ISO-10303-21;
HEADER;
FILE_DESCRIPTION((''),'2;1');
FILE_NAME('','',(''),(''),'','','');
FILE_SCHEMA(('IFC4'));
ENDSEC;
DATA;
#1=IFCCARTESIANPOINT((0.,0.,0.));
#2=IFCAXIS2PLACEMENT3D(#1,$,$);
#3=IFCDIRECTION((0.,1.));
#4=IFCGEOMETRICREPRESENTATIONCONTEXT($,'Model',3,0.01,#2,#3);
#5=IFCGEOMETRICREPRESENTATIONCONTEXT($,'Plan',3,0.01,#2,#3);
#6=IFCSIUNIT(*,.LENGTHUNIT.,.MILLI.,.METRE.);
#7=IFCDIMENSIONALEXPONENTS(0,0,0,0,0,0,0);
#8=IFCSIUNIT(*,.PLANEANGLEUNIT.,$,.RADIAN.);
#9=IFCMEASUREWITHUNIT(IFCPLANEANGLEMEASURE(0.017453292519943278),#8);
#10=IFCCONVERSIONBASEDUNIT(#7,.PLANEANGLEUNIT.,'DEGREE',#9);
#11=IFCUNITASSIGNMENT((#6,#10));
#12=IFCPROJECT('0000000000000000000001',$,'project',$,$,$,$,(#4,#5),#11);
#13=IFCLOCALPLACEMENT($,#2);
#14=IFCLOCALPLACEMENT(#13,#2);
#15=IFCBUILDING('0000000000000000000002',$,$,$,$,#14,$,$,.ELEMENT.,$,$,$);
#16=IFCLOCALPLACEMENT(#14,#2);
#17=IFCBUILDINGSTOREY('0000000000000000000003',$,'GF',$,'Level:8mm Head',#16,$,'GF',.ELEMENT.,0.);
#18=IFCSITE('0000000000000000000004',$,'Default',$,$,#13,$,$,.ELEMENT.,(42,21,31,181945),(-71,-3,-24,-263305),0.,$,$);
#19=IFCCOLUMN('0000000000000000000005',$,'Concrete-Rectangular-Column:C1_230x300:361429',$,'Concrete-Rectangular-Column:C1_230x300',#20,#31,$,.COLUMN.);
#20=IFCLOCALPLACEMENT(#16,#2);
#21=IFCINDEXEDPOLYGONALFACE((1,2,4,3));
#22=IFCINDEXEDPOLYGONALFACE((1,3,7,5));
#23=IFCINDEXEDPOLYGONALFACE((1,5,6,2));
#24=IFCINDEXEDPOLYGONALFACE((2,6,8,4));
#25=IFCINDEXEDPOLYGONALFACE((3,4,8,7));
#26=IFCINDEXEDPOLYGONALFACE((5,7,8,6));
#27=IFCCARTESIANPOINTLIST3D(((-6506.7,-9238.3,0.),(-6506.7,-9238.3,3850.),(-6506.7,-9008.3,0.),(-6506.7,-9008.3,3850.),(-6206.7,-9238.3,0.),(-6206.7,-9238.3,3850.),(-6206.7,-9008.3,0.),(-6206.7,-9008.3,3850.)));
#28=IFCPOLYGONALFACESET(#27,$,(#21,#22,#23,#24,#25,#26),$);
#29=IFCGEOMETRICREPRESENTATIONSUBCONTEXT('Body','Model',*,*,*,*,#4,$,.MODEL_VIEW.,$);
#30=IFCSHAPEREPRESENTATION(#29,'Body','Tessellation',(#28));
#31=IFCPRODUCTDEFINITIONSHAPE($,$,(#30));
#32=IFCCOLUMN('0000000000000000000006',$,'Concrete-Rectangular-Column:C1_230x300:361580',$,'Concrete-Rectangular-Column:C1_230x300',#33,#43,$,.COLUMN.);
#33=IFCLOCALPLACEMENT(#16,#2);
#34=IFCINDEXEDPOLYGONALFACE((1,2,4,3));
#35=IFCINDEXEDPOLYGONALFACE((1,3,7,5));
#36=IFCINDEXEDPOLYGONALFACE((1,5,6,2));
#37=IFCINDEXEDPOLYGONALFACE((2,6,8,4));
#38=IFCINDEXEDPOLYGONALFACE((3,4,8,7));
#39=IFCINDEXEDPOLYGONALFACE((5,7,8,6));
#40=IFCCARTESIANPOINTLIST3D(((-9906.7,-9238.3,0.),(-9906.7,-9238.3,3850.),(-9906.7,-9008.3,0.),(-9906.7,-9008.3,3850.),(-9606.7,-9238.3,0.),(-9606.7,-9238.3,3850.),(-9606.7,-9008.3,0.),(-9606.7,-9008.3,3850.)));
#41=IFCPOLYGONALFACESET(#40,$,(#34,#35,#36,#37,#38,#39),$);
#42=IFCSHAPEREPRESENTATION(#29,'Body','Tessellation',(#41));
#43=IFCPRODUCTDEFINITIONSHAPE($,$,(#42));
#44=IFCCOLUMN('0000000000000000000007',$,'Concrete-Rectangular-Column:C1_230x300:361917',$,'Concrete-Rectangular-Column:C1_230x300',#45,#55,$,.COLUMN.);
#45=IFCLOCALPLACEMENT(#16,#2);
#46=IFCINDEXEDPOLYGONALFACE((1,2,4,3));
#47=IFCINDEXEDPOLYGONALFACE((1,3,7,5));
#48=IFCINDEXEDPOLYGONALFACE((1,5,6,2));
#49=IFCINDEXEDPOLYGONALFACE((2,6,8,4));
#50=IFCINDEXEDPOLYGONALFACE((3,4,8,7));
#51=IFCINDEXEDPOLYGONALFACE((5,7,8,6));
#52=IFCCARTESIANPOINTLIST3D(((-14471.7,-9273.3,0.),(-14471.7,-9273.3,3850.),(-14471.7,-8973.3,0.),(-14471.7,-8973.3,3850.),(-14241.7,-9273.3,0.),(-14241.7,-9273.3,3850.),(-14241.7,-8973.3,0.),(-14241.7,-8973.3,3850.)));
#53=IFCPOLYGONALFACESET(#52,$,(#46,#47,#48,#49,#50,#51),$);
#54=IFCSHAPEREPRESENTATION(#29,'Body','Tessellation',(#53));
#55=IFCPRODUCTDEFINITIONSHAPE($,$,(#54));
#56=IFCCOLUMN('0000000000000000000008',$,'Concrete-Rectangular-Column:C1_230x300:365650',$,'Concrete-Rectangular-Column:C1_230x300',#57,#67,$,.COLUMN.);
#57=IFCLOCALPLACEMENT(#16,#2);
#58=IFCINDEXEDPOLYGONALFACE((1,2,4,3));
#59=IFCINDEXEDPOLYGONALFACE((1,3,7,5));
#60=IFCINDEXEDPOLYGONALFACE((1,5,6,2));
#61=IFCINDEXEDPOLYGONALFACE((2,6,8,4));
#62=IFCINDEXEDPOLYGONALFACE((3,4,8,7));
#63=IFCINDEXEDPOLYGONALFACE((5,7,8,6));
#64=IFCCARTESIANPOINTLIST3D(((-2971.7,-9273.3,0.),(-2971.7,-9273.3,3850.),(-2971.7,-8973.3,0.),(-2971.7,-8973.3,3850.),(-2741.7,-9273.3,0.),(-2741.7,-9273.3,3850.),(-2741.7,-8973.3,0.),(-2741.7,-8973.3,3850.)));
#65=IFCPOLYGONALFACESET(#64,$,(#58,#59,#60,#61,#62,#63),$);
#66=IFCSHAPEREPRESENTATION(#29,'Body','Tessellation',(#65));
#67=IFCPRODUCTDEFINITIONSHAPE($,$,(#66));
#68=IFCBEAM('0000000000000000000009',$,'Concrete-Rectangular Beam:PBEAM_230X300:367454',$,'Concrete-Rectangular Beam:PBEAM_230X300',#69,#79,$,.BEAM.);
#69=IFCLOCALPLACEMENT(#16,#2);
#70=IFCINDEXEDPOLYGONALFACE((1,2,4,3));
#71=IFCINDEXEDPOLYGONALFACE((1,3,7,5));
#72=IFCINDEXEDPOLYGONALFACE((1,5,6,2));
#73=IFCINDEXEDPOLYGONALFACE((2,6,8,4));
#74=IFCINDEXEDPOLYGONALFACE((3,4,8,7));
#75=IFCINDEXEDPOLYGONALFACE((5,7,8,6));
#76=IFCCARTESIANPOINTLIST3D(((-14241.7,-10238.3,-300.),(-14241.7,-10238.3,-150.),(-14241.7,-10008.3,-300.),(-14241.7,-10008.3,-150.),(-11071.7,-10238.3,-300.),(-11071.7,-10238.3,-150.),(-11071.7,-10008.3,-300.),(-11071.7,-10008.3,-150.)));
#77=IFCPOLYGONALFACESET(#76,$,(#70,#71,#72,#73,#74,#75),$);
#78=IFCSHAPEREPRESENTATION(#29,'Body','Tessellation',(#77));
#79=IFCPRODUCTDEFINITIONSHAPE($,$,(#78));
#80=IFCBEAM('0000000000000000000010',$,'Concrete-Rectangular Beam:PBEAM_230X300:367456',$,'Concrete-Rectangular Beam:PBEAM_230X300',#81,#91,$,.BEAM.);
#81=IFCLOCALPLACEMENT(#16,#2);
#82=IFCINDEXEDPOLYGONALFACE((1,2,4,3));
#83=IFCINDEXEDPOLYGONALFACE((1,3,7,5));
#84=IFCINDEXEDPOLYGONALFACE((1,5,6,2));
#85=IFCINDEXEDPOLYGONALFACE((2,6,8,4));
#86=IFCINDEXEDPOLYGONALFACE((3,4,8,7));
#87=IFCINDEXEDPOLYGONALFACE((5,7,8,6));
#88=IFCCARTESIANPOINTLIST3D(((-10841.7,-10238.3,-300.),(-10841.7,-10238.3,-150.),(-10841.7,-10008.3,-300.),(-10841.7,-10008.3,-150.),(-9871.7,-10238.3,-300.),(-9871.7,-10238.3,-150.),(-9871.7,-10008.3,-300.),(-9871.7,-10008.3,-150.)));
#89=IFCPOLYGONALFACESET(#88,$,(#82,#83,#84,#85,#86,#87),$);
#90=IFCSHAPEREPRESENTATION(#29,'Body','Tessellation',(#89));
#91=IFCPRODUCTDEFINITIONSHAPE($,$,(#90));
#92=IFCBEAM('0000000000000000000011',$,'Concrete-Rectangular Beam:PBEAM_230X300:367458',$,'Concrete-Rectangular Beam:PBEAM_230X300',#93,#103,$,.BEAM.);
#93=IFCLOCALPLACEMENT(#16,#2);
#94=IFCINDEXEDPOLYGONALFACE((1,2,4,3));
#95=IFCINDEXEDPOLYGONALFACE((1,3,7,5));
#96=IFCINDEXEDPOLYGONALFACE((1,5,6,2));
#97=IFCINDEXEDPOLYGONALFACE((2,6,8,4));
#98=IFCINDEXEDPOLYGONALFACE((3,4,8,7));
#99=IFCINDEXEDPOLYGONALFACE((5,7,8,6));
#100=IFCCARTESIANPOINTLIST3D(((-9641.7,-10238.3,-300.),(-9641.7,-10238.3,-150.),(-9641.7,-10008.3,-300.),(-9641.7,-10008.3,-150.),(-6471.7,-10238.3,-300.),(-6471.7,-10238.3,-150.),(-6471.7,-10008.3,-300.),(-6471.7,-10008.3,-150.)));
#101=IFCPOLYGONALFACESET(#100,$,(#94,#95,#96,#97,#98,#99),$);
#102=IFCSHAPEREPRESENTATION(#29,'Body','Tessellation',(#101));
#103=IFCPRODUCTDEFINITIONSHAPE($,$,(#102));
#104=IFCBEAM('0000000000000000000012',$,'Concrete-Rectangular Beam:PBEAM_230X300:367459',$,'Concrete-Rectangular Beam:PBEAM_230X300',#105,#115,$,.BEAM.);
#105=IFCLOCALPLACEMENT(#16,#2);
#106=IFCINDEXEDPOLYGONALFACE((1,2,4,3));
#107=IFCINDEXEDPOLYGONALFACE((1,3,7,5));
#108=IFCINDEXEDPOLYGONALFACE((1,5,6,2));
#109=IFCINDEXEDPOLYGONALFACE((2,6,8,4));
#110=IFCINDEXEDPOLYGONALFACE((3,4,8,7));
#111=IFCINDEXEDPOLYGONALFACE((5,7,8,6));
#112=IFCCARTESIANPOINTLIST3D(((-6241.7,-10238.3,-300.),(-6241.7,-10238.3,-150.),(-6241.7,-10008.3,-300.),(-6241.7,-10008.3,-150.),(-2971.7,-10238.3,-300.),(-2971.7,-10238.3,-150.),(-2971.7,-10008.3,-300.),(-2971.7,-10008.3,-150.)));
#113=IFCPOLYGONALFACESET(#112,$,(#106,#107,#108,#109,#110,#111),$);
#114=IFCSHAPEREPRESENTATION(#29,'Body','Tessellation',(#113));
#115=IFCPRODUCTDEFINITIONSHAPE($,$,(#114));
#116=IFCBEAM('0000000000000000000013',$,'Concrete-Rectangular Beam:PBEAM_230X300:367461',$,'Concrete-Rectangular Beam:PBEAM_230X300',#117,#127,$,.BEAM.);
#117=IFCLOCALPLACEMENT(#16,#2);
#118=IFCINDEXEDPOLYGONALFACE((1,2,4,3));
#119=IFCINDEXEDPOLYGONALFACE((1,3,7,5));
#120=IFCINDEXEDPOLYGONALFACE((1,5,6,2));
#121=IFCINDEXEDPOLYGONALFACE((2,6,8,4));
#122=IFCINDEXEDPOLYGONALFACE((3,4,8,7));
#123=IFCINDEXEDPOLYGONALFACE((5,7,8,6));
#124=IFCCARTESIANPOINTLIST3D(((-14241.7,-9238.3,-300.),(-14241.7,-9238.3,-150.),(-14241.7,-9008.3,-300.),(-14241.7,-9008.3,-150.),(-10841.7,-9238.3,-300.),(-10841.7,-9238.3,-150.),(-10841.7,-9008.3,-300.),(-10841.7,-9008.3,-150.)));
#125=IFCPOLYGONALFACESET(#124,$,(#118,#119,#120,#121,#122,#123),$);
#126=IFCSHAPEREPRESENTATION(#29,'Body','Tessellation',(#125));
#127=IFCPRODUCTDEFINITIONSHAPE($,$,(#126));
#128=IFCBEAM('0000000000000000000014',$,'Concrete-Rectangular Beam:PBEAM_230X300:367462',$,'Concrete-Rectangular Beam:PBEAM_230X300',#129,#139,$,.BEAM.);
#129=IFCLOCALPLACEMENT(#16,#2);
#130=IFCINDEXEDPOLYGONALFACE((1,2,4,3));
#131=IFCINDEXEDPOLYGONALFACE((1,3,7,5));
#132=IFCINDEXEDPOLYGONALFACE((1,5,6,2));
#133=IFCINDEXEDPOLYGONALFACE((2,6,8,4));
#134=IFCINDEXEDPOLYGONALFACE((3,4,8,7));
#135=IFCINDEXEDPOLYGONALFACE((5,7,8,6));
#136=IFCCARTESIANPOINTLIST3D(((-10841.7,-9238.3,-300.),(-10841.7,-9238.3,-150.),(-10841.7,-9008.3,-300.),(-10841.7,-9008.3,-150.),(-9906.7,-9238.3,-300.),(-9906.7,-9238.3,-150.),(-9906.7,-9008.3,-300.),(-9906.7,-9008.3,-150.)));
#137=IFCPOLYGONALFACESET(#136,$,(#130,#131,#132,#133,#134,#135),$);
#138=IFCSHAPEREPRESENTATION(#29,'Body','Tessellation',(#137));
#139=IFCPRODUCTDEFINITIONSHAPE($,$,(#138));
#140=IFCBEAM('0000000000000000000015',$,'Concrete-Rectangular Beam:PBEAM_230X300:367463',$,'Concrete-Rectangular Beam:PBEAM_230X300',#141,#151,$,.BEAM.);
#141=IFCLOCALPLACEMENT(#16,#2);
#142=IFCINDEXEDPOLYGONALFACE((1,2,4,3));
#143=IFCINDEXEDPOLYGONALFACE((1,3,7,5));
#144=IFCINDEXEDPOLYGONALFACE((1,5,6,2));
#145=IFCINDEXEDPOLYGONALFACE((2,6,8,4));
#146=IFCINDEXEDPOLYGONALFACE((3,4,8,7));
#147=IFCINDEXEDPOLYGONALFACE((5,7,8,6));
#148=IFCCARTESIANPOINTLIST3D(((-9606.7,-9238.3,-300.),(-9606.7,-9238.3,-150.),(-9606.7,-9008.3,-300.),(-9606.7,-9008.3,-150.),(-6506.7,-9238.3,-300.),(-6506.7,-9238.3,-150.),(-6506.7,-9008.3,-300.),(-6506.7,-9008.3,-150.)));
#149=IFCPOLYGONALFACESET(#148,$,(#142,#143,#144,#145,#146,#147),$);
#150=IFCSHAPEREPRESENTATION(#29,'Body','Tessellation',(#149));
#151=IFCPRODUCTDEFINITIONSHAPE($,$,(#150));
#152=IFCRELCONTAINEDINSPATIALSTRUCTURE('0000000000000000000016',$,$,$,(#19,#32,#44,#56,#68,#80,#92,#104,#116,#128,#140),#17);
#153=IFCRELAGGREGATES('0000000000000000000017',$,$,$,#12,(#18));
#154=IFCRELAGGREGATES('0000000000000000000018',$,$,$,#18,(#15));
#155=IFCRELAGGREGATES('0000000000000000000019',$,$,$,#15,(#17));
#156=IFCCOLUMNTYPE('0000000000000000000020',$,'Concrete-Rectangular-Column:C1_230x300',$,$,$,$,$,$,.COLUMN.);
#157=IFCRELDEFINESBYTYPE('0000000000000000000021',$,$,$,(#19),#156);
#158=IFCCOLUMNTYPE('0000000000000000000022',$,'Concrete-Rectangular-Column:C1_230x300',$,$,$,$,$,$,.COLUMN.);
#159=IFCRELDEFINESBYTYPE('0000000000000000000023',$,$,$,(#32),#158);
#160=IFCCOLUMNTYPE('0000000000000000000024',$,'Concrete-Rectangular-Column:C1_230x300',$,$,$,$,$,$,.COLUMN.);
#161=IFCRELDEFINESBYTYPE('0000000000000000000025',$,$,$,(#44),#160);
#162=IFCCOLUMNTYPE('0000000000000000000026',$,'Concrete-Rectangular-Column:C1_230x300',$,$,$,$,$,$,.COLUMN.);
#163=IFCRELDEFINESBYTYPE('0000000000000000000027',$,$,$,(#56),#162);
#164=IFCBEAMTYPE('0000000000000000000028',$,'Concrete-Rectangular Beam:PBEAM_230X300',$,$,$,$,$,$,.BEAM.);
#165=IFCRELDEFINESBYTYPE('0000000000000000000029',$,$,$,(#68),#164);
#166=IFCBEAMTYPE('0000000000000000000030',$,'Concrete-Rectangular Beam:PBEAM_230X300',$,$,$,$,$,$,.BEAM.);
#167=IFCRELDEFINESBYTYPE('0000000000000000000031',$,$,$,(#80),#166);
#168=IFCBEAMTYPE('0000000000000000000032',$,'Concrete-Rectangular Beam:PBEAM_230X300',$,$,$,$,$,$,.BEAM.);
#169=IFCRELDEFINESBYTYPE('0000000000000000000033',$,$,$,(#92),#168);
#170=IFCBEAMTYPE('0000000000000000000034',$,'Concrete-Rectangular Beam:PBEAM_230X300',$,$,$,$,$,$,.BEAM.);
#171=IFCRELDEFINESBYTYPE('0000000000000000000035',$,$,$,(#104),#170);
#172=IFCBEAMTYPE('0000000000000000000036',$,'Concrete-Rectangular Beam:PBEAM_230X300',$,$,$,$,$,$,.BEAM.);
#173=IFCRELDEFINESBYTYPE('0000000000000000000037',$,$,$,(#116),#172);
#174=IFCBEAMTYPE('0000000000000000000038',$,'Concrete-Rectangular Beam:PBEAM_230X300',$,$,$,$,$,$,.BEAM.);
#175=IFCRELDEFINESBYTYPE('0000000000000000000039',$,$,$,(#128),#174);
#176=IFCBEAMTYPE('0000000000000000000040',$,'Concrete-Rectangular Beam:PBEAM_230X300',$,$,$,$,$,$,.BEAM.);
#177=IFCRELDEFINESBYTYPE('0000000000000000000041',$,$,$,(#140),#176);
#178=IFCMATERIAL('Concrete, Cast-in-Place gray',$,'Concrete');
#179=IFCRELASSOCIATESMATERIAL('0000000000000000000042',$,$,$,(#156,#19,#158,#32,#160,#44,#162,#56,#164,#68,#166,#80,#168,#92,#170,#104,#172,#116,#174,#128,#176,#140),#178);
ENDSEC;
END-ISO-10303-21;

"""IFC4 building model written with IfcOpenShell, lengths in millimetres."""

from ifc_helpers import new_model, entity, si_unit, converted_unit, direction, frame, origin, place, context, subcontext, project, spatial, indexed_curve, outline, extrude, source, transform, mapped, material, type_object, type_shapes, element, save


model = new_model("IFC4")

# Units and contexts
model_context = context("Model", 3, precision=0.01, world=origin(), true_north=direction((0.0, 1.0)))
plan_context = context("Plan", 3, precision=0.01, world=origin(), true_north=direction((0.0, 1.0)))
body_context = subcontext(model_context, "Body", "Model", "MODEL_VIEW")
ifc_project = project(units=[si_unit("LENGTHUNIT", "METRE", prefix="MILLI"), converted_unit("PLANEANGLEUNIT", "DEGREE", entity("IfcPlaneAngleMeasure", 0.017453292519943278), si_unit("PLANEANGLEUNIT", "RADIAN"), dimensions=[0, 0, 0, 0, 0, 0, 0])], contexts=[model_context, plan_context])

# Site, building, storey
site_placement = place(None, origin())
site = spatial("IfcSite", under=ifc_project, at=site_placement, Name="Default", CompositionType="ELEMENT", RefLatitude=(42, 21, 31, 181945), RefLongitude=(-71, -3, -24, -263305), RefElevation=0.0)
building_placement = place(site_placement, origin())
building = spatial("IfcBuilding", under=site, at=building_placement, CompositionType="ELEMENT")
storey_placement = place(building_placement, origin())
storey = spatial("IfcBuildingStorey", under=building, at=storey_placement, Name="GF", ObjectType="Level:8mm Head", LongName="GF", CompositionType="ELEMENT", Elevation=0.0)

# Columns
ifc_material = material(Name="Concrete, Cast-in-Place gray", Category="Concrete")
column_type_1 = type_object("IfcColumnType", Name="Concrete-Rectangular-Column:C1_230x300", PredefinedType="COLUMN", material=ifc_material)
shared_shape_1 = source(origin(), body_context, "Body", "SweptSolid", [
    extrude(outline(indexed_curve([(-115.0, -150.0), (115.0, -150.0), (115.0, 150.0), (-115.0, 150.0), (-115.0, -150.0)], self_intersect=False)), frame((-6356.7, -9123.3, 0.0), z_axis=(0.0, 0.0, 1.0), x_axis=(0.0, -1.0, 0.0)), (0.0, 0.0, 1.0), 3850.0),
])
type_shapes(column_type_1, [shared_shape_1])
column_1_placement = place(storey_placement, origin())
element("IfcColumn", 1, at=column_1_placement, inside=storey, type_object=column_type_1, material=ifc_material, Name="Concrete-Rectangular-Column:C1_230x300:361429", ObjectType="Concrete-Rectangular-Column:C1_230x300", PredefinedType="COLUMN", context=body_context, shape_type="MappedRepresentation", body=[
    mapped(shared_shape_1, transform((0.0, 0.0, 0.0), scale=1.0)),
])
column_type_2 = type_object("IfcColumnType", Name="Concrete-Rectangular-Column:C1_230x300", PredefinedType="COLUMN", material=ifc_material)
shared_shape_2 = source(origin(), body_context, "Body", "SweptSolid", [
    extrude(outline(indexed_curve([(-115.0, -150.0), (115.0, -150.0), (115.0, 150.0), (-115.0, 150.0), (-115.0, -150.0)], self_intersect=False)), frame((-9756.7, -9123.3, 0.0), z_axis=(0.0, 0.0, 1.0), x_axis=(0.0, -1.0, 0.0)), (0.0, 0.0, 1.0), 3850.0),
])
type_shapes(column_type_2, [shared_shape_2])
column_2_placement = place(storey_placement, origin())
element("IfcColumn", 2, at=column_2_placement, inside=storey, type_object=column_type_2, material=ifc_material, Name="Concrete-Rectangular-Column:C1_230x300:361580", ObjectType="Concrete-Rectangular-Column:C1_230x300", PredefinedType="COLUMN", context=body_context, shape_type="MappedRepresentation", body=[
    mapped(shared_shape_2, transform((0.0, 0.0, 0.0), scale=1.0)),
])
column_type_3 = type_object("IfcColumnType", Name="Concrete-Rectangular-Column:C1_230x300", PredefinedType="COLUMN", material=ifc_material)
shared_shape_3 = source(origin(), body_context, "Body", "SweptSolid", [
    extrude(outline(indexed_curve([(-1925.0, -150.0), (1925.0, -150.0), (1925.0, 150.0), (-1925.0, 150.0), (-1925.0, -150.0)], self_intersect=False)), frame((-14471.7, -9123.3, 1925.0), z_axis=(1.0, 0.0, 0.0), x_axis=(0.0, 0.0, 1.0)), (0.0, 0.0, 1.0), 230.0),
])
type_shapes(column_type_3, [shared_shape_3])
column_3_placement = place(storey_placement, origin())
element("IfcColumn", 3, at=column_3_placement, inside=storey, type_object=column_type_3, material=ifc_material, Name="Concrete-Rectangular-Column:C1_230x300:361917", ObjectType="Concrete-Rectangular-Column:C1_230x300", PredefinedType="COLUMN", context=body_context, shape_type="MappedRepresentation", body=[
    mapped(shared_shape_3, transform((0.0, 0.0, 0.0), scale=1.0)),
])
column_type_4 = type_object("IfcColumnType", Name="Concrete-Rectangular-Column:C1_230x300", PredefinedType="COLUMN", material=ifc_material)
shared_shape_4 = source(origin(), body_context, "Body", "SweptSolid", [
    extrude(outline(indexed_curve([(-1925.0, -150.0), (1925.0, -150.0), (1925.0, 150.0), (-1925.0, 150.0), (-1925.0, -150.0)], self_intersect=False)), frame((-2971.7, -9123.3, 1925.0), z_axis=(1.0, 0.0, 0.0), x_axis=(0.0, 0.0, 1.0)), (0.0, 0.0, 1.0), 230.0),
])
type_shapes(column_type_4, [shared_shape_4])
column_4_placement = place(storey_placement, origin())
element("IfcColumn", 4, at=column_4_placement, inside=storey, type_object=column_type_4, material=ifc_material, Name="Concrete-Rectangular-Column:C1_230x300:365650", ObjectType="Concrete-Rectangular-Column:C1_230x300", PredefinedType="COLUMN", context=body_context, shape_type="MappedRepresentation", body=[
    mapped(shared_shape_4, transform((0.0, 0.0, 0.0), scale=1.0)),
])

# Beams
beam_type_1 = type_object("IfcBeamType", Name="Concrete-Rectangular Beam:PBEAM_230X300", PredefinedType="BEAM", material=ifc_material)
shared_shape_5 = source(origin(), body_context, "Body", "SweptSolid", [
    extrude(outline(indexed_curve([(-75.0, -115.0), (75.0, -115.0), (75.0, 115.0), (-75.0, 115.0), (-75.0, -115.0)], self_intersect=False)), frame((-14241.7, -10123.3, -225.0), z_axis=(1.0, 0.0, 0.0), x_axis=(0.0, 0.0, -1.0)), (0.0, 0.0, 1.0), 3170.0),
])
type_shapes(beam_type_1, [shared_shape_5])
beam_1_placement = place(storey_placement, origin())
element("IfcBeam", 5, at=beam_1_placement, inside=storey, type_object=beam_type_1, material=ifc_material, Name="Concrete-Rectangular Beam:PBEAM_230X300:367454", ObjectType="Concrete-Rectangular Beam:PBEAM_230X300", PredefinedType="BEAM", context=body_context, shape_type="MappedRepresentation", body=[
    mapped(shared_shape_5, transform((0.0, 0.0, 0.0), scale=1.0)),
])
beam_type_2 = type_object("IfcBeamType", Name="Concrete-Rectangular Beam:PBEAM_230X300", PredefinedType="BEAM", material=ifc_material)
shared_shape_6 = source(origin(), body_context, "Body", "SweptSolid", [
    extrude(outline(indexed_curve([(-75.0, -115.0), (75.0, -115.0), (75.0, 115.0), (-75.0, 115.0), (-75.0, -115.0)], self_intersect=False)), frame((-10841.7, -10123.3, -225.0), z_axis=(1.0, 0.0, 0.0), x_axis=(0.0, 0.0, -1.0)), (0.0, 0.0, 1.0), 970.0),
])
type_shapes(beam_type_2, [shared_shape_6])
beam_2_placement = place(storey_placement, origin())
element("IfcBeam", 6, at=beam_2_placement, inside=storey, type_object=beam_type_2, material=ifc_material, Name="Concrete-Rectangular Beam:PBEAM_230X300:367456", ObjectType="Concrete-Rectangular Beam:PBEAM_230X300", PredefinedType="BEAM", context=body_context, shape_type="MappedRepresentation", body=[
    mapped(shared_shape_6, transform((0.0, 0.0, 0.0), scale=1.0)),
])
beam_type_3 = type_object("IfcBeamType", Name="Concrete-Rectangular Beam:PBEAM_230X300", PredefinedType="BEAM", material=ifc_material)
shared_shape_7 = source(origin(), body_context, "Body", "SweptSolid", [
    extrude(outline(indexed_curve([(-75.0, -115.0), (75.0, -115.0), (75.0, 115.0), (-75.0, 115.0), (-75.0, -115.0)], self_intersect=False)), frame((-9641.7, -10123.3, -225.0), z_axis=(1.0, 0.0, 0.0), x_axis=(0.0, 0.0, -1.0)), (0.0, 0.0, 1.0), 3170.0),
])
type_shapes(beam_type_3, [shared_shape_7])
beam_3_placement = place(storey_placement, origin())
element("IfcBeam", 7, at=beam_3_placement, inside=storey, type_object=beam_type_3, material=ifc_material, Name="Concrete-Rectangular Beam:PBEAM_230X300:367458", ObjectType="Concrete-Rectangular Beam:PBEAM_230X300", PredefinedType="BEAM", context=body_context, shape_type="MappedRepresentation", body=[
    mapped(shared_shape_7, transform((0.0, 0.0, 0.0), scale=1.0)),
])
beam_type_4 = type_object("IfcBeamType", Name="Concrete-Rectangular Beam:PBEAM_230X300", PredefinedType="BEAM", material=ifc_material)
shared_shape_8 = source(origin(), body_context, "Body", "SweptSolid", [
    extrude(outline(indexed_curve([(-75.0, -115.0), (75.0, -115.0), (75.0, 115.0), (-75.0, 115.0), (-75.0, -115.0)], self_intersect=False)), frame((-6241.7, -10123.3, -225.0), z_axis=(1.0, 0.0, 0.0), x_axis=(0.0, 0.0, -1.0)), (0.0, 0.0, 1.0), 3270.0),
])
type_shapes(beam_type_4, [shared_shape_8])
beam_4_placement = place(storey_placement, origin())
element("IfcBeam", 8, at=beam_4_placement, inside=storey, type_object=beam_type_4, material=ifc_material, Name="Concrete-Rectangular Beam:PBEAM_230X300:367459", ObjectType="Concrete-Rectangular Beam:PBEAM_230X300", PredefinedType="BEAM", context=body_context, shape_type="MappedRepresentation", body=[
    mapped(shared_shape_8, transform((0.0, 0.0, 0.0), scale=1.0)),
])
beam_type_5 = type_object("IfcBeamType", Name="Concrete-Rectangular Beam:PBEAM_230X300", PredefinedType="BEAM", material=ifc_material)
shared_shape_9 = source(origin(), body_context, "Body", "SweptSolid", [
    extrude(outline(indexed_curve([(-75.0, -115.0), (75.0, -115.0), (75.0, 115.0), (-75.0, 115.0), (-75.0, -115.0)], self_intersect=False)), frame((-14241.7, -9123.3, -225.0), z_axis=(1.0, 0.0, 0.0), x_axis=(0.0, 0.0, -1.0)), (0.0, 0.0, 1.0), 3400.0),
])
type_shapes(beam_type_5, [shared_shape_9])
beam_5_placement = place(storey_placement, origin())
element("IfcBeam", 9, at=beam_5_placement, inside=storey, type_object=beam_type_5, material=ifc_material, Name="Concrete-Rectangular Beam:PBEAM_230X300:367461", ObjectType="Concrete-Rectangular Beam:PBEAM_230X300", PredefinedType="BEAM", context=body_context, shape_type="MappedRepresentation", body=[
    mapped(shared_shape_9, transform((0.0, 0.0, 0.0), scale=1.0)),
])
beam_type_6 = type_object("IfcBeamType", Name="Concrete-Rectangular Beam:PBEAM_230X300", PredefinedType="BEAM", material=ifc_material)
shared_shape_10 = source(origin(), body_context, "Body", "SweptSolid", [
    extrude(outline(indexed_curve([(-75.0, -115.0), (75.0, -115.0), (75.0, 115.0), (-75.0, 115.0), (-75.0, -115.0)], self_intersect=False)), frame((-10841.7, -9123.3, -225.0), z_axis=(1.0, 0.0, 0.0), x_axis=(0.0, 0.0, -1.0)), (0.0, 0.0, 1.0), 935.0),
])
type_shapes(beam_type_6, [shared_shape_10])
beam_6_placement = place(storey_placement, origin())
element("IfcBeam", 10, at=beam_6_placement, inside=storey, type_object=beam_type_6, material=ifc_material, Name="Concrete-Rectangular Beam:PBEAM_230X300:367462", ObjectType="Concrete-Rectangular Beam:PBEAM_230X300", PredefinedType="BEAM", context=body_context, shape_type="MappedRepresentation", body=[
    mapped(shared_shape_10, transform((0.0, 0.0, 0.0), scale=1.0)),
])
beam_type_7 = type_object("IfcBeamType", Name="Concrete-Rectangular Beam:PBEAM_230X300", PredefinedType="BEAM", material=ifc_material)
shared_shape_11 = source(origin(), body_context, "Body", "SweptSolid", [
    extrude(outline(indexed_curve([(-75.0, -115.0), (75.0, -115.0), (75.0, 115.0), (-75.0, 115.0), (-75.0, -115.0)], self_intersect=False)), frame((-9606.7, -9123.3, -225.0), z_axis=(1.0, 0.0, 0.0), x_axis=(0.0, 0.0, -1.0)), (0.0, 0.0, 1.0), 3100.0),
])
type_shapes(beam_type_7, [shared_shape_11])
beam_7_placement = place(storey_placement, origin())
element("IfcBeam", 11, at=beam_7_placement, inside=storey, type_object=beam_type_7, material=ifc_material, Name="Concrete-Rectangular Beam:PBEAM_230X300:367463", ObjectType="Concrete-Rectangular Beam:PBEAM_230X300", PredefinedType="BEAM", context=body_context, shape_type="MappedRepresentation", body=[
    mapped(shared_shape_11, transform((0.0, 0.0, 0.0), scale=1.0)),
])

save(model, "model.ifc")
